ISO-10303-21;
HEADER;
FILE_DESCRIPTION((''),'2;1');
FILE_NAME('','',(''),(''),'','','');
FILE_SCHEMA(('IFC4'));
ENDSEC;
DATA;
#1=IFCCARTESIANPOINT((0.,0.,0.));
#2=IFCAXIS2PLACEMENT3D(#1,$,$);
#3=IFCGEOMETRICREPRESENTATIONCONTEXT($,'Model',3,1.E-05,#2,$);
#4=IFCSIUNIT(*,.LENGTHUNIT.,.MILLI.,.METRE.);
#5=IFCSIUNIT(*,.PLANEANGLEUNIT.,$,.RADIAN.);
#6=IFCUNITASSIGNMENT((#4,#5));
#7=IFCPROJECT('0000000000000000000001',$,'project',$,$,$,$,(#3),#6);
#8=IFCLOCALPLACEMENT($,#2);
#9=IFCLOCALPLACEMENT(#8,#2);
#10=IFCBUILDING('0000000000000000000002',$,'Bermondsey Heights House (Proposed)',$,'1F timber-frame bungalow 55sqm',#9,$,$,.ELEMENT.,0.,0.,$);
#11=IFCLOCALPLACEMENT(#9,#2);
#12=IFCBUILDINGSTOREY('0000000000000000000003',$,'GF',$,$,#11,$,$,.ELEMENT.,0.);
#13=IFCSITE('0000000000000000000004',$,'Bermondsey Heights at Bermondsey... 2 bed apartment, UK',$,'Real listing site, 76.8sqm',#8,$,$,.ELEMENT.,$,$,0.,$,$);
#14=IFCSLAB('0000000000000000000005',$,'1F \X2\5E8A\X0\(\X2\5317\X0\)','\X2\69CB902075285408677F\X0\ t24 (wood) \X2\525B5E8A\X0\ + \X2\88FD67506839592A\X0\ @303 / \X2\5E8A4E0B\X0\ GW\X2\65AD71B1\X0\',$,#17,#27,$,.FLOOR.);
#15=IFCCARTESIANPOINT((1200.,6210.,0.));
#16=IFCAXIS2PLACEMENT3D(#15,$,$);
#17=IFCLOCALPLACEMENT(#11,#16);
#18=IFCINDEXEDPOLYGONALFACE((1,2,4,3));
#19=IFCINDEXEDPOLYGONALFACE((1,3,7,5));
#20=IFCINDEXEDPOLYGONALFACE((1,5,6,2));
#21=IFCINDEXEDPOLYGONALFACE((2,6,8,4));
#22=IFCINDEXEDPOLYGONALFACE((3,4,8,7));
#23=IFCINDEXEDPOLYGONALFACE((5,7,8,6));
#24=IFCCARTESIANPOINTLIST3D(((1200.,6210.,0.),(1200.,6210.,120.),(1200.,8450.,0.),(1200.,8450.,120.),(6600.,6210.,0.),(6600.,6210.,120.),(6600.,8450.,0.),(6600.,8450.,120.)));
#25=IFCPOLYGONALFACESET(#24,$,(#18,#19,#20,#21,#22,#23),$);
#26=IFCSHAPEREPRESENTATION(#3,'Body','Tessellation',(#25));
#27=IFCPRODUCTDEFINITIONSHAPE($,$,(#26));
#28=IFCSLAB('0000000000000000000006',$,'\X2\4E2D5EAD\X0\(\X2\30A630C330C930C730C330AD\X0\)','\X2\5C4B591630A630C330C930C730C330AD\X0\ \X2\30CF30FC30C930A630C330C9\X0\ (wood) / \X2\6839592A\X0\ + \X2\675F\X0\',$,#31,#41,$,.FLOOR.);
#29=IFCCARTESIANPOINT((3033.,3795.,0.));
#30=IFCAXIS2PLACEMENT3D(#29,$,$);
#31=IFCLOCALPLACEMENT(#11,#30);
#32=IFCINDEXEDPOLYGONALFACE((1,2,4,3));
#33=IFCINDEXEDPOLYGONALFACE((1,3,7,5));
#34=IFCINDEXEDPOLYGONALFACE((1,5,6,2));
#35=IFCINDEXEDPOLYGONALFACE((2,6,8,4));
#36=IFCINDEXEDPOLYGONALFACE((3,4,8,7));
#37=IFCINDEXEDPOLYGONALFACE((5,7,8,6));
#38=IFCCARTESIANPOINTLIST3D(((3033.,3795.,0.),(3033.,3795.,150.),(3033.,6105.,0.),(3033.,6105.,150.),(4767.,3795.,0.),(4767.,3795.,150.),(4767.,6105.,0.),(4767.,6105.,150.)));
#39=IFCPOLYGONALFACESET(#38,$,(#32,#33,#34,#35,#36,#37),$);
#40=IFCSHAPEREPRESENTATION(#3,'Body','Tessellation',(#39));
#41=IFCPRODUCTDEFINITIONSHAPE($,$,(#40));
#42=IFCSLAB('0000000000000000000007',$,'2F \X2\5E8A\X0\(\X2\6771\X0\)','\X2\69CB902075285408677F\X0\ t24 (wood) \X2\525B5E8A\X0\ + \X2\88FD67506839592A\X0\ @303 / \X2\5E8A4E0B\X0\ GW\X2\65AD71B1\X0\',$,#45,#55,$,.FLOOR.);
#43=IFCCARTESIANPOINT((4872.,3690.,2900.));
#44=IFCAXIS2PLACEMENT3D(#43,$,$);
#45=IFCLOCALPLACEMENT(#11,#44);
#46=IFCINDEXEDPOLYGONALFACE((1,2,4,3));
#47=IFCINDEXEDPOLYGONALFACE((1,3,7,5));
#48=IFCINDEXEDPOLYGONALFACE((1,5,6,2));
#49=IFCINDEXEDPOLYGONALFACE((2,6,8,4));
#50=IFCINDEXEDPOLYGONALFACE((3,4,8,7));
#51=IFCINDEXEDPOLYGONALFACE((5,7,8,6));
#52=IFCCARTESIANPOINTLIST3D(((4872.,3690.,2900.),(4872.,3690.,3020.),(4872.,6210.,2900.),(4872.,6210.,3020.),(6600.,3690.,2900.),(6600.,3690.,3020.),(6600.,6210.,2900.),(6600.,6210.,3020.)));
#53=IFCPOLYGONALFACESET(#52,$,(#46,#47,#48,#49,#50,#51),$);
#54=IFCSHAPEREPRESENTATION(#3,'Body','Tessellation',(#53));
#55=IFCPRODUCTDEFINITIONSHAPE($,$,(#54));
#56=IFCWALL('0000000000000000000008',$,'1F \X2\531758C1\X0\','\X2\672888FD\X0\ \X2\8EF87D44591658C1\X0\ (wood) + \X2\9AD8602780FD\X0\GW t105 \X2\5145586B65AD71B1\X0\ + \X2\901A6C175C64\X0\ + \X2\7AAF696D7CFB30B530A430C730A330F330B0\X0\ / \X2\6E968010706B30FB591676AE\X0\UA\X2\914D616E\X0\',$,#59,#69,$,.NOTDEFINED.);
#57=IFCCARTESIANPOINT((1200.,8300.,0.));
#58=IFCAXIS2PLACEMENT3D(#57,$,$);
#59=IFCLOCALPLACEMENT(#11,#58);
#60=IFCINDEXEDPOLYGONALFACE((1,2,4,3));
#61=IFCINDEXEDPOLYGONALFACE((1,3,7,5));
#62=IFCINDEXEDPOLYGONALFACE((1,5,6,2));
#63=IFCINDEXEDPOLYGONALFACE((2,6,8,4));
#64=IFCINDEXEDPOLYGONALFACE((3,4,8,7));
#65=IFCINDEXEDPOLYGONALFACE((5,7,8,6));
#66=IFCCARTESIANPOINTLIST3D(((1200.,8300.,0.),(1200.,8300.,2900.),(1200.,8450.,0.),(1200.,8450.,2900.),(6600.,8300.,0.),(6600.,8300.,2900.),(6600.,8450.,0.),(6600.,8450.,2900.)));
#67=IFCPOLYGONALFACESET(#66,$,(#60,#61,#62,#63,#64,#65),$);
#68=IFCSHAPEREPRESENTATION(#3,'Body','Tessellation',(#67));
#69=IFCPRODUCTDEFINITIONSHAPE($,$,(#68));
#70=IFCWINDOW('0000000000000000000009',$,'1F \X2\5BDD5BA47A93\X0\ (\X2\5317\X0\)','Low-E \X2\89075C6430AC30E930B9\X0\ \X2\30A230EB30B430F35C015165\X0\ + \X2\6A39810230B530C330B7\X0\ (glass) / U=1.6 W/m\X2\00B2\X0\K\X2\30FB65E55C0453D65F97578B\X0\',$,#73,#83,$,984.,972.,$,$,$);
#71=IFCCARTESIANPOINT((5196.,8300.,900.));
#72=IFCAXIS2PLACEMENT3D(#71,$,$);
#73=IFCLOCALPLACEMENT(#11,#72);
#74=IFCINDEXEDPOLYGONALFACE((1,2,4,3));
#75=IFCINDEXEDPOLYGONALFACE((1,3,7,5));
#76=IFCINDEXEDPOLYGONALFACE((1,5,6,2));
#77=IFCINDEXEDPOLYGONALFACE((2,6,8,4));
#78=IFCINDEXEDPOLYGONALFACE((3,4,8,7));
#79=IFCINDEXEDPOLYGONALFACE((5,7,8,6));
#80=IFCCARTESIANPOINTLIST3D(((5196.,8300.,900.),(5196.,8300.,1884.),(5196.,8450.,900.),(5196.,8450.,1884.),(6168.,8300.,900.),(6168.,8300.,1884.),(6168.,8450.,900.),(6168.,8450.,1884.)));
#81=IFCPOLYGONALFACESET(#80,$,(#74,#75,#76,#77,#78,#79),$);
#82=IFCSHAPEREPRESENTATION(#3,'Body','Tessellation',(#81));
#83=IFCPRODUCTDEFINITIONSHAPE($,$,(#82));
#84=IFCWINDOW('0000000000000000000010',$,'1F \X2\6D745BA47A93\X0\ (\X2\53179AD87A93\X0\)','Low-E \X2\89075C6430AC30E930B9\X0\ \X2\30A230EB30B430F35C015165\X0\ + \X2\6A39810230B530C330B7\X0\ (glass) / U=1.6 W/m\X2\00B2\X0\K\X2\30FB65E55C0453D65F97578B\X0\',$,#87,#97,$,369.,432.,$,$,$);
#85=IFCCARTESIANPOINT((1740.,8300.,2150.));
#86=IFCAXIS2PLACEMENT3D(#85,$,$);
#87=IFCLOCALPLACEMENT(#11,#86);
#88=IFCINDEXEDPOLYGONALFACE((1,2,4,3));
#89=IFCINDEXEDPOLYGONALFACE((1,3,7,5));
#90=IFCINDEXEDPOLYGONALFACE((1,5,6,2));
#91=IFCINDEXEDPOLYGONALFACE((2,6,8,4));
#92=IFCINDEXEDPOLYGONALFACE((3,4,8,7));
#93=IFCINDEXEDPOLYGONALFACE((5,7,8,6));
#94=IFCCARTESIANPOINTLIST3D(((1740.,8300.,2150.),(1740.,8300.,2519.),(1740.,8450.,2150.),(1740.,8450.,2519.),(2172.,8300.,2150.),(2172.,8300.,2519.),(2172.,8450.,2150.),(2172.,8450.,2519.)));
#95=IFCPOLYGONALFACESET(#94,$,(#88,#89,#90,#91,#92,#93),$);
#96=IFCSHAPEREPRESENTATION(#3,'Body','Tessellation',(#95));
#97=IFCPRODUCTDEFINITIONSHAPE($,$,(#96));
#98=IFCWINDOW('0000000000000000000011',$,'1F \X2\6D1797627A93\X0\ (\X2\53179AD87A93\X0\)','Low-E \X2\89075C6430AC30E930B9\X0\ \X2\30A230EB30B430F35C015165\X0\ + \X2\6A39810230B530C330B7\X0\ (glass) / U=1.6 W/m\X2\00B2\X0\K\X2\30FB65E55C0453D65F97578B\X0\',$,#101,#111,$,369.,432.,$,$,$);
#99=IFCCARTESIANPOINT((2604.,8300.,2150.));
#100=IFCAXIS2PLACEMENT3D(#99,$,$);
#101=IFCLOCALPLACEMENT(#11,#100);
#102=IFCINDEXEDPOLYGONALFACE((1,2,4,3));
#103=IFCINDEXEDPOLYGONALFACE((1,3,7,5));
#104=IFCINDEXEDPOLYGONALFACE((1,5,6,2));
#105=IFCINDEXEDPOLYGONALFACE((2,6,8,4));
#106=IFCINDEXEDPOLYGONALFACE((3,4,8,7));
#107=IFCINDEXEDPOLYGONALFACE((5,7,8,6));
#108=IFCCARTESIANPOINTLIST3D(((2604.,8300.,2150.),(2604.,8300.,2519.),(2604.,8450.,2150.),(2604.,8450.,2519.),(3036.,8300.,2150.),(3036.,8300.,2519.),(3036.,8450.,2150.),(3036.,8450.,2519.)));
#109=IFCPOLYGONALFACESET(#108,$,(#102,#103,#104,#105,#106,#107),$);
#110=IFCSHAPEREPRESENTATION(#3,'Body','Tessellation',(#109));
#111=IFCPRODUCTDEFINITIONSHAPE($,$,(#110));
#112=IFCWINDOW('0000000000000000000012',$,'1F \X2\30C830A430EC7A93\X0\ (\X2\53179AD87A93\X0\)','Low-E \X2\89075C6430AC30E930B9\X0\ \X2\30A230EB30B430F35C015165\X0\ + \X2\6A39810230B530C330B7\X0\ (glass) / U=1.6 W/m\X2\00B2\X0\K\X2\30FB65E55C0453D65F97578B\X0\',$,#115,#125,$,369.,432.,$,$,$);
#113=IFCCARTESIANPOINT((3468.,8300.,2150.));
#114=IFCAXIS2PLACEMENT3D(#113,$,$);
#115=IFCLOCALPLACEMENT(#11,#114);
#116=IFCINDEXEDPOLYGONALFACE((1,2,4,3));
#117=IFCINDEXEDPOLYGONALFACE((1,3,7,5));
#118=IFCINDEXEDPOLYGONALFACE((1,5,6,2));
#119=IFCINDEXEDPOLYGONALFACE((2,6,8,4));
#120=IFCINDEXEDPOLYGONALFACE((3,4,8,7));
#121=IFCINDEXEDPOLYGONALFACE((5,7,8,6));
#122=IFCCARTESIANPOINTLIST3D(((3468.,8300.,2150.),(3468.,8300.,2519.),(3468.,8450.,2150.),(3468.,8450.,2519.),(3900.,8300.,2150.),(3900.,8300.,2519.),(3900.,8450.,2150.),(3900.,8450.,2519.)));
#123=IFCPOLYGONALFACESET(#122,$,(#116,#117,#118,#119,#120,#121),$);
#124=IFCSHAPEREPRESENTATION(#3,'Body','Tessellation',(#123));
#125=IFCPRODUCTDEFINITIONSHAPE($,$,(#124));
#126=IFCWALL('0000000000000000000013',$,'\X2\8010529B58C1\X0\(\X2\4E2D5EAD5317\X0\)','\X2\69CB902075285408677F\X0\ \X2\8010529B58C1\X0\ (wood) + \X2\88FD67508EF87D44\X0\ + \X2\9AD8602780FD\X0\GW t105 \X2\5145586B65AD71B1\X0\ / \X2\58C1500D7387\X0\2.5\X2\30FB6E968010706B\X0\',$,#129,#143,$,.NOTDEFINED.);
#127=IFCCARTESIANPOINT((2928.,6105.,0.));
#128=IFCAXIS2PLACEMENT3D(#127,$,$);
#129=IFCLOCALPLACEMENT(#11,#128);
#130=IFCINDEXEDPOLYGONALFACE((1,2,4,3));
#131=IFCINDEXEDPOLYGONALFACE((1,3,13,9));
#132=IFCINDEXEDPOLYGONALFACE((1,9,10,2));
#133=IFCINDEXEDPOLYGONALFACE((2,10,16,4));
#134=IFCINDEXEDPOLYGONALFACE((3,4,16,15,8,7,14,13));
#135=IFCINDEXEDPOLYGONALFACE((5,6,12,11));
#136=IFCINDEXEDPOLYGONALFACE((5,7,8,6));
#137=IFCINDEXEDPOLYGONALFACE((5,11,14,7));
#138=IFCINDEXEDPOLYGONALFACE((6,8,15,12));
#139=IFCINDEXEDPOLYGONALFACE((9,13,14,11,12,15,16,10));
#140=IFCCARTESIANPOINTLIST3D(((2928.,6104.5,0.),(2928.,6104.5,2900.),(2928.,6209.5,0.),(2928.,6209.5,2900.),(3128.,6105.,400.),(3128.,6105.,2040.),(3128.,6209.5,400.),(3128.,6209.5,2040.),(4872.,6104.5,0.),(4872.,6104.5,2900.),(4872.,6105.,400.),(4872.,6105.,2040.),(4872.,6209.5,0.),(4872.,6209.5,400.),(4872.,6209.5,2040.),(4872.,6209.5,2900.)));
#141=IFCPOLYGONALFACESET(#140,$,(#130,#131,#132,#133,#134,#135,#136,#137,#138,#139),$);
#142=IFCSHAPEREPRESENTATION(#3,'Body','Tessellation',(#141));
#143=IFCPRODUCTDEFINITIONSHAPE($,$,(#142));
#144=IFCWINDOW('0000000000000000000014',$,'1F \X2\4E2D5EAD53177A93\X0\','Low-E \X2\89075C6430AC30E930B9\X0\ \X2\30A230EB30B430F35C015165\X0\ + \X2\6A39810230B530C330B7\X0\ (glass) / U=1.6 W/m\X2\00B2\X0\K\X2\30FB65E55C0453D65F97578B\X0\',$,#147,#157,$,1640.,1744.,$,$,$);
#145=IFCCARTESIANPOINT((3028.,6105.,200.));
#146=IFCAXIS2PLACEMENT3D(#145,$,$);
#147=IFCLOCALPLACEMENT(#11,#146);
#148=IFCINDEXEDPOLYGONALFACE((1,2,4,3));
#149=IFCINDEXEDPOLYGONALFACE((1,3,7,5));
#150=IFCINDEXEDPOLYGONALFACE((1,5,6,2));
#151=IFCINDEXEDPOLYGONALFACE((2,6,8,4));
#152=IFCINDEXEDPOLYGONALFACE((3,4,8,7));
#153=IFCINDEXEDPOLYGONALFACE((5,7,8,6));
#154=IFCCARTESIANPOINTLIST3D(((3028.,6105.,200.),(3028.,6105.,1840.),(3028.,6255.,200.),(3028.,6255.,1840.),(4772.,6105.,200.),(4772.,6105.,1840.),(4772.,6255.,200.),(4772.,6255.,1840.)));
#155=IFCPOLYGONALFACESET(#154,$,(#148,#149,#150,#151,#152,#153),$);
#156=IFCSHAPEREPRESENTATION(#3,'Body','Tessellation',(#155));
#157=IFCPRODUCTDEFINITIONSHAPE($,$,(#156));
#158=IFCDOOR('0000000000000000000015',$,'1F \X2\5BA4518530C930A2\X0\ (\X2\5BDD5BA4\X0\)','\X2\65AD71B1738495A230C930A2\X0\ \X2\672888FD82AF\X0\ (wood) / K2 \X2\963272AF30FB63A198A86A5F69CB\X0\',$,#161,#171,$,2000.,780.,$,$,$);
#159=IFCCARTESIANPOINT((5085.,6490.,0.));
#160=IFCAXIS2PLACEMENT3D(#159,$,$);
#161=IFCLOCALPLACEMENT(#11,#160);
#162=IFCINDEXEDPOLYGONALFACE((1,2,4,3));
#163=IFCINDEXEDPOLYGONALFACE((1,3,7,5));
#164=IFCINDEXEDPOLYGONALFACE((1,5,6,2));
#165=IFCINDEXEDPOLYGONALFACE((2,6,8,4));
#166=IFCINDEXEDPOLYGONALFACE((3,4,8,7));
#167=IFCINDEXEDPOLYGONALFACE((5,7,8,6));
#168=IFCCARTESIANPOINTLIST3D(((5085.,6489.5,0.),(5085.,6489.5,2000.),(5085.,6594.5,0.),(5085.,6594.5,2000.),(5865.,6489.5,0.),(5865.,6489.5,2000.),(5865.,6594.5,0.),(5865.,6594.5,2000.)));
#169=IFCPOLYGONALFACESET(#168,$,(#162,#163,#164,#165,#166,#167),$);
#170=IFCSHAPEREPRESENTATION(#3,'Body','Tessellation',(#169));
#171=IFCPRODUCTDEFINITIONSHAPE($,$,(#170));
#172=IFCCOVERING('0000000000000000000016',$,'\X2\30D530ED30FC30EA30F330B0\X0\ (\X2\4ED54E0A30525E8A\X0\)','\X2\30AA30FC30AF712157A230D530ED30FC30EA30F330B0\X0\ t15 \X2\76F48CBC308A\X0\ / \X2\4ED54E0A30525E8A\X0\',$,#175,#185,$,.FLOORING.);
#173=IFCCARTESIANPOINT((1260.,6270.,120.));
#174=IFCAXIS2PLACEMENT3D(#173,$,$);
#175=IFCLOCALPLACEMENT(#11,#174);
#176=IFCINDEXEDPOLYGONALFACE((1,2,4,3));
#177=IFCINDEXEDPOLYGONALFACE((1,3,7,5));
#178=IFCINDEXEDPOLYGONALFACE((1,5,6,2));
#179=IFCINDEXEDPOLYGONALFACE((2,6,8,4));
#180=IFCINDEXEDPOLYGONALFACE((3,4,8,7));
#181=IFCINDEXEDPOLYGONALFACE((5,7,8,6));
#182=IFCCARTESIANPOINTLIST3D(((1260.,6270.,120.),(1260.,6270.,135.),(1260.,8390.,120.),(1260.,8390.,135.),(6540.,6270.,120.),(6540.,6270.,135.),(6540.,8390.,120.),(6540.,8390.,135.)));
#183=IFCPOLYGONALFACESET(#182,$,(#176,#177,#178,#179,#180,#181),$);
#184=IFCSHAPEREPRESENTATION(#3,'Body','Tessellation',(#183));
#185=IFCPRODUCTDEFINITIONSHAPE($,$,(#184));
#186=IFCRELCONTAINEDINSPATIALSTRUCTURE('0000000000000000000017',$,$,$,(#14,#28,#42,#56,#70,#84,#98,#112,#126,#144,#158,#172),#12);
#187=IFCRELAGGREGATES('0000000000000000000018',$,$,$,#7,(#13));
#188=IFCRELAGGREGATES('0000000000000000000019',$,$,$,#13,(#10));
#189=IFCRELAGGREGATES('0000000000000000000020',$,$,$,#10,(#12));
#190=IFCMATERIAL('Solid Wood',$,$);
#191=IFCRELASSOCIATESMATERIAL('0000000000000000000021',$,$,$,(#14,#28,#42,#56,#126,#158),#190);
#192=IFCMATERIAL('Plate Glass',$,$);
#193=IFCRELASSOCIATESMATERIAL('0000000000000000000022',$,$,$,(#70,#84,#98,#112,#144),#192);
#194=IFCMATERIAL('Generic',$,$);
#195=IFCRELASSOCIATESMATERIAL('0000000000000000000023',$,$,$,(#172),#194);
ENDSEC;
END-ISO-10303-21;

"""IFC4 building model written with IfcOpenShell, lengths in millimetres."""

from ifc_helpers import new_model, si_unit, frame, frame_2d, origin, place, context, project, spatial, rectangle, extrude, material, element, fill, save


model = new_model("IFC4")

# Units and contexts
model_context = context("Model", 3, precision=1e-05, world=origin())
ifc_project = project(units=[si_unit("LENGTHUNIT", "METRE", prefix="MILLI"), si_unit("PLANEANGLEUNIT", "RADIAN")], contexts=[model_context])

# Site, building, storey
site_placement = place(None, origin())
site = spatial("IfcSite", under=ifc_project, at=site_placement, Name="Bermondsey Heights at Bermondsey... 2 bed apartment, UK", ObjectType="Real listing site, 76.8sqm", CompositionType="ELEMENT", RefElevation=0.0)
building_placement = place(site_placement, origin())
building = spatial("IfcBuilding", under=site, at=building_placement, Name="Bermondsey Heights House (Proposed)", ObjectType="1F timber-frame bungalow 55sqm", CompositionType="ELEMENT", ElevationOfRefHeight=0.0, ElevationOfTerrain=0.0)
storey_placement = place(building_placement, origin())
storey = spatial("IfcBuildingStorey", under=building, at=storey_placement, Name="GF", CompositionType="ELEMENT", Elevation=0.0)

# Slabs
ifc_material_1 = material(Name="Solid Wood")
slab_1_placement = place(storey_placement, frame((1200.0, 6210.0, 0.0)))
element("IfcSlab", 1, at=slab_1_placement, inside=storey, material=ifc_material_1, Name="1F 床(北)", Description="構造用合板 t24 (wood) 剛床 + 製材根太 @303 / 床下 GW断熱", PredefinedType="FLOOR", context=model_context, shape_type="SweptSolid", body=[
    extrude(rectangle(XDim=5400.0, YDim=2240.0, at=frame_2d((2700.0, 1120.0))), frame((1200.0, 6210.0, 0.0)), (0.0, 0.0, 1.0), 120.0),
])
slab_2_placement = place(storey_placement, frame((3033.0, 3795.0, 0.0)))
element("IfcSlab", 2, at=slab_2_placement, inside=storey, material=ifc_material_1, Name="中庭(ウッドデッキ)", Description="屋外ウッドデッキ ハードウッド (wood) / 根太 + 束", PredefinedType="FLOOR", context=model_context, shape_type="SweptSolid", body=[
    extrude(rectangle(XDim=1734.0, YDim=2310.0, at=frame_2d((867.0, 1155.0))), frame((3033.0, 3795.0, 0.0)), (0.0, 0.0, 1.0), 150.0),
])
slab_3_placement = place(storey_placement, frame((4872.0, 3690.0, 2900.0)))
element("IfcSlab", 3, at=slab_3_placement, inside=storey, material=ifc_material_1, Name="2F 床(東)", Description="構造用合板 t24 (wood) 剛床 + 製材根太 @303 / 床下 GW断熱", PredefinedType="FLOOR", context=model_context, shape_type="SweptSolid", body=[
    extrude(rectangle(XDim=1728.0, YDim=2520.0, at=frame_2d((864.0, 1260.0))), frame((4872.0, 3690.0, 2900.0)), (0.0, 0.0, 1.0), 120.0),
])

# Wall, openings, windows
wall_1_placement = place(storey_placement, frame((1200.0, 8300.0, 0.0)))
wall_1 = element("IfcWall", 4, at=wall_1_placement, inside=storey, material=ifc_material_1, Name="1F 北壁", Description="木製 軸組外壁 (wood) + 高性能GW t105 充填断熱 + 通気層 + 窯業系サイディング / 準耐火・外皮UA配慮", PredefinedType="NOTDEFINED", context=model_context, shape_type="SweptSolid", body=[
    extrude(rectangle(XDim=5400.0, YDim=150.0, at=frame_2d((2700.0, 75.0))), frame((1200.0, 8300.0, 0.0)), (0.0, 0.0, 1.0), 2900.0),
])
opening_1_placement = place(storey_placement, frame((5196.0, 8300.0, 900.0)))
opening_1 = element("IfcOpeningElement", 5, at=opening_1_placement, cuts=wall_1, PredefinedType="NOTDEFINED", context=model_context, shape_type="SweptSolid", body=[
    extrude(rectangle(XDim=972.0, YDim=150.0, at=frame_2d((486.0, 75.0))), frame((5196.0, 8300.0, 900.0)), (0.0, 0.0, 1.0), 984.0),
])
opening_2_placement = place(storey_placement, frame((1740.0, 8300.0, 2150.0)))
opening_2 = element("IfcOpeningElement", 6, at=opening_2_placement, cuts=wall_1, PredefinedType="NOTDEFINED", context=model_context, shape_type="SweptSolid", body=[
    extrude(rectangle(XDim=432.0, YDim=150.0, at=frame_2d((216.0, 75.0))), frame((1740.0, 8300.0, 2150.0)), (0.0, 0.0, 1.0), 369.0),
])
opening_3_placement = place(storey_placement, frame((2604.0, 8300.0, 2150.0)))
opening_3 = element("IfcOpeningElement", 7, at=opening_3_placement, cuts=wall_1, PredefinedType="NOTDEFINED", context=model_context, shape_type="SweptSolid", body=[
    extrude(rectangle(XDim=432.0, YDim=150.0, at=frame_2d((216.0, 75.0))), frame((2604.0, 8300.0, 2150.0)), (0.0, 0.0, 1.0), 369.0),
])
opening_4_placement = place(storey_placement, frame((3468.0, 8300.0, 2150.0)))
opening_4 = element("IfcOpeningElement", 8, at=opening_4_placement, cuts=wall_1, PredefinedType="NOTDEFINED", context=model_context, shape_type="SweptSolid", body=[
    extrude(rectangle(XDim=432.0, YDim=150.0, at=frame_2d((216.0, 75.0))), frame((3468.0, 8300.0, 2150.0)), (0.0, 0.0, 1.0), 369.0),
])
ifc_material_2 = material(Name="Plate Glass")
window_1_placement = place(storey_placement, frame((5196.0, 8300.0, 900.0)))
window_1 = element("IfcWindow", 9, at=window_1_placement, inside=storey, material=ifc_material_2, Name="1F 寝室窓 (北)", Description="Low-E 複層ガラス アルゴン封入 + 樹脂サッシ (glass) / U=1.6 W/m²K・日射取得型", OverallHeight=984.0, OverallWidth=972.0, context=model_context, shape_type="SweptSolid", body=[
    extrude(rectangle(XDim=972.0, YDim=150.0, at=frame_2d((486.0, 75.0))), frame((5196.0, 8300.0, 900.0)), (0.0, 0.0, 1.0), 984.0),
])
fill(opening_1, window_1)
window_2_placement = place(storey_placement, frame((1740.0, 8300.0, 2150.0)))
window_2 = element("IfcWindow", 10, at=window_2_placement, inside=storey, material=ifc_material_2, Name="1F 浴室窓 (北高窓)", Description="Low-E 複層ガラス アルゴン封入 + 樹脂サッシ (glass) / U=1.6 W/m²K・日射取得型", OverallHeight=369.0, OverallWidth=432.0, context=model_context, shape_type="SweptSolid", body=[
    extrude(rectangle(XDim=432.0, YDim=150.0, at=frame_2d((216.0, 75.0))), frame((1740.0, 8300.0, 2150.0)), (0.0, 0.0, 1.0), 369.0),
])
fill(opening_2, window_2)
window_3_placement = place(storey_placement, frame((2604.0, 8300.0, 2150.0)))
window_3 = element("IfcWindow", 11, at=window_3_placement, inside=storey, material=ifc_material_2, Name="1F 洗面窓 (北高窓)", Description="Low-E 複層ガラス アルゴン封入 + 樹脂サッシ (glass) / U=1.6 W/m²K・日射取得型", OverallHeight=369.0, OverallWidth=432.0, context=model_context, shape_type="SweptSolid", body=[
    extrude(rectangle(XDim=432.0, YDim=150.0, at=frame_2d((216.0, 75.0))), frame((2604.0, 8300.0, 2150.0)), (0.0, 0.0, 1.0), 369.0),
])
fill(opening_3, window_3)
window_4_placement = place(storey_placement, frame((3468.0, 8300.0, 2150.0)))
window_4 = element("IfcWindow", 12, at=window_4_placement, inside=storey, material=ifc_material_2, Name="1F トイレ窓 (北高窓)", Description="Low-E 複層ガラス アルゴン封入 + 樹脂サッシ (glass) / U=1.6 W/m²K・日射取得型", OverallHeight=369.0, OverallWidth=432.0, context=model_context, shape_type="SweptSolid", body=[
    extrude(rectangle(XDim=432.0, YDim=150.0, at=frame_2d((216.0, 75.0))), frame((3468.0, 8300.0, 2150.0)), (0.0, 0.0, 1.0), 369.0),
])
fill(opening_4, window_4)

# Wall, opening, window
wall_2_placement = place(storey_placement, frame((2928.0, 6105.0, 0.0)))
wall_2 = element("IfcWall", 13, at=wall_2_placement, inside=storey, material=ifc_material_1, Name="耐力壁(中庭北)", Description="構造用合板 耐力壁 (wood) + 製材軸組 + 高性能GW t105 充填断熱 / 壁倍率2.5・準耐火", PredefinedType="NOTDEFINED", context=model_context, shape_type="SweptSolid", body=[
    extrude(rectangle(XDim=1944.0, YDim=105.0, at=frame_2d((972.0, 52.0))), frame((2928.0, 6105.0, 0.0)), (0.0, 0.0, 1.0), 2900.0),
])
opening_5_placement = place(storey_placement, frame((3028.0, 6105.0, 200.0)))
opening_5 = element("IfcOpeningElement", 14, at=opening_5_placement, cuts=wall_2, PredefinedType="NOTDEFINED", context=model_context, shape_type="SweptSolid", body=[
    extrude(rectangle(XDim=1744.0, YDim=150.0, at=frame_2d((872.0, 75.0))), frame((3028.0, 6105.0, 200.0)), (0.0, 0.0, 1.0), 1640.0),
])
window_5_placement = place(storey_placement, frame((3028.0, 6105.0, 200.0)))
window_5 = element("IfcWindow", 15, at=window_5_placement, inside=storey, material=ifc_material_2, Name="1F 中庭北窓", Description="Low-E 複層ガラス アルゴン封入 + 樹脂サッシ (glass) / U=1.6 W/m²K・日射取得型", OverallHeight=1640.0, OverallWidth=1744.0, context=model_context, shape_type="SweptSolid", body=[
    extrude(rectangle(XDim=1744.0, YDim=150.0, at=frame_2d((872.0, 75.0))), frame((3028.0, 6105.0, 200.0)), (0.0, 0.0, 1.0), 1640.0),
])
fill(opening_5, window_5)

# Door
door_1_placement = place(storey_placement, frame((5085.0, 6490.0, 0.0)))
element("IfcDoor", 16, at=door_1_placement, inside=storey, material=ifc_material_1, Name="1F 室内ドア (寝室)", Description="断熱玄関ドア 木製芯 (wood) / K2 防犯・採風機構", OverallHeight=2000.0, OverallWidth=780.0, context=model_context, shape_type="SweptSolid", body=[
    extrude(rectangle(XDim=780.0, YDim=105.0, at=frame_2d((390.0, 52.0))), frame((5085.0, 6490.0, 0.0)), (0.0, 0.0, 1.0), 2000.0),
])

# Covering
ifc_material_3 = material(Name="Generic")
covering_1_placement = place(storey_placement, frame((1260.0, 6270.0, 120.0)))
element("IfcCovering", 17, at=covering_1_placement, inside=storey, material=ifc_material_3, Name="フローリング (仕上げ床)", Description="オーク無垢フローリング t15 直貼り / 仕上げ床", PredefinedType="FLOORING", context=model_context, shape_type="SweptSolid", body=[
    extrude(rectangle(XDim=5280.0, YDim=2120.0, at=frame_2d((2640.0, 1060.0))), frame((1260.0, 6270.0, 120.0)), (0.0, 0.0, 1.0), 15.0),
])

save(model, "model.ifc")
